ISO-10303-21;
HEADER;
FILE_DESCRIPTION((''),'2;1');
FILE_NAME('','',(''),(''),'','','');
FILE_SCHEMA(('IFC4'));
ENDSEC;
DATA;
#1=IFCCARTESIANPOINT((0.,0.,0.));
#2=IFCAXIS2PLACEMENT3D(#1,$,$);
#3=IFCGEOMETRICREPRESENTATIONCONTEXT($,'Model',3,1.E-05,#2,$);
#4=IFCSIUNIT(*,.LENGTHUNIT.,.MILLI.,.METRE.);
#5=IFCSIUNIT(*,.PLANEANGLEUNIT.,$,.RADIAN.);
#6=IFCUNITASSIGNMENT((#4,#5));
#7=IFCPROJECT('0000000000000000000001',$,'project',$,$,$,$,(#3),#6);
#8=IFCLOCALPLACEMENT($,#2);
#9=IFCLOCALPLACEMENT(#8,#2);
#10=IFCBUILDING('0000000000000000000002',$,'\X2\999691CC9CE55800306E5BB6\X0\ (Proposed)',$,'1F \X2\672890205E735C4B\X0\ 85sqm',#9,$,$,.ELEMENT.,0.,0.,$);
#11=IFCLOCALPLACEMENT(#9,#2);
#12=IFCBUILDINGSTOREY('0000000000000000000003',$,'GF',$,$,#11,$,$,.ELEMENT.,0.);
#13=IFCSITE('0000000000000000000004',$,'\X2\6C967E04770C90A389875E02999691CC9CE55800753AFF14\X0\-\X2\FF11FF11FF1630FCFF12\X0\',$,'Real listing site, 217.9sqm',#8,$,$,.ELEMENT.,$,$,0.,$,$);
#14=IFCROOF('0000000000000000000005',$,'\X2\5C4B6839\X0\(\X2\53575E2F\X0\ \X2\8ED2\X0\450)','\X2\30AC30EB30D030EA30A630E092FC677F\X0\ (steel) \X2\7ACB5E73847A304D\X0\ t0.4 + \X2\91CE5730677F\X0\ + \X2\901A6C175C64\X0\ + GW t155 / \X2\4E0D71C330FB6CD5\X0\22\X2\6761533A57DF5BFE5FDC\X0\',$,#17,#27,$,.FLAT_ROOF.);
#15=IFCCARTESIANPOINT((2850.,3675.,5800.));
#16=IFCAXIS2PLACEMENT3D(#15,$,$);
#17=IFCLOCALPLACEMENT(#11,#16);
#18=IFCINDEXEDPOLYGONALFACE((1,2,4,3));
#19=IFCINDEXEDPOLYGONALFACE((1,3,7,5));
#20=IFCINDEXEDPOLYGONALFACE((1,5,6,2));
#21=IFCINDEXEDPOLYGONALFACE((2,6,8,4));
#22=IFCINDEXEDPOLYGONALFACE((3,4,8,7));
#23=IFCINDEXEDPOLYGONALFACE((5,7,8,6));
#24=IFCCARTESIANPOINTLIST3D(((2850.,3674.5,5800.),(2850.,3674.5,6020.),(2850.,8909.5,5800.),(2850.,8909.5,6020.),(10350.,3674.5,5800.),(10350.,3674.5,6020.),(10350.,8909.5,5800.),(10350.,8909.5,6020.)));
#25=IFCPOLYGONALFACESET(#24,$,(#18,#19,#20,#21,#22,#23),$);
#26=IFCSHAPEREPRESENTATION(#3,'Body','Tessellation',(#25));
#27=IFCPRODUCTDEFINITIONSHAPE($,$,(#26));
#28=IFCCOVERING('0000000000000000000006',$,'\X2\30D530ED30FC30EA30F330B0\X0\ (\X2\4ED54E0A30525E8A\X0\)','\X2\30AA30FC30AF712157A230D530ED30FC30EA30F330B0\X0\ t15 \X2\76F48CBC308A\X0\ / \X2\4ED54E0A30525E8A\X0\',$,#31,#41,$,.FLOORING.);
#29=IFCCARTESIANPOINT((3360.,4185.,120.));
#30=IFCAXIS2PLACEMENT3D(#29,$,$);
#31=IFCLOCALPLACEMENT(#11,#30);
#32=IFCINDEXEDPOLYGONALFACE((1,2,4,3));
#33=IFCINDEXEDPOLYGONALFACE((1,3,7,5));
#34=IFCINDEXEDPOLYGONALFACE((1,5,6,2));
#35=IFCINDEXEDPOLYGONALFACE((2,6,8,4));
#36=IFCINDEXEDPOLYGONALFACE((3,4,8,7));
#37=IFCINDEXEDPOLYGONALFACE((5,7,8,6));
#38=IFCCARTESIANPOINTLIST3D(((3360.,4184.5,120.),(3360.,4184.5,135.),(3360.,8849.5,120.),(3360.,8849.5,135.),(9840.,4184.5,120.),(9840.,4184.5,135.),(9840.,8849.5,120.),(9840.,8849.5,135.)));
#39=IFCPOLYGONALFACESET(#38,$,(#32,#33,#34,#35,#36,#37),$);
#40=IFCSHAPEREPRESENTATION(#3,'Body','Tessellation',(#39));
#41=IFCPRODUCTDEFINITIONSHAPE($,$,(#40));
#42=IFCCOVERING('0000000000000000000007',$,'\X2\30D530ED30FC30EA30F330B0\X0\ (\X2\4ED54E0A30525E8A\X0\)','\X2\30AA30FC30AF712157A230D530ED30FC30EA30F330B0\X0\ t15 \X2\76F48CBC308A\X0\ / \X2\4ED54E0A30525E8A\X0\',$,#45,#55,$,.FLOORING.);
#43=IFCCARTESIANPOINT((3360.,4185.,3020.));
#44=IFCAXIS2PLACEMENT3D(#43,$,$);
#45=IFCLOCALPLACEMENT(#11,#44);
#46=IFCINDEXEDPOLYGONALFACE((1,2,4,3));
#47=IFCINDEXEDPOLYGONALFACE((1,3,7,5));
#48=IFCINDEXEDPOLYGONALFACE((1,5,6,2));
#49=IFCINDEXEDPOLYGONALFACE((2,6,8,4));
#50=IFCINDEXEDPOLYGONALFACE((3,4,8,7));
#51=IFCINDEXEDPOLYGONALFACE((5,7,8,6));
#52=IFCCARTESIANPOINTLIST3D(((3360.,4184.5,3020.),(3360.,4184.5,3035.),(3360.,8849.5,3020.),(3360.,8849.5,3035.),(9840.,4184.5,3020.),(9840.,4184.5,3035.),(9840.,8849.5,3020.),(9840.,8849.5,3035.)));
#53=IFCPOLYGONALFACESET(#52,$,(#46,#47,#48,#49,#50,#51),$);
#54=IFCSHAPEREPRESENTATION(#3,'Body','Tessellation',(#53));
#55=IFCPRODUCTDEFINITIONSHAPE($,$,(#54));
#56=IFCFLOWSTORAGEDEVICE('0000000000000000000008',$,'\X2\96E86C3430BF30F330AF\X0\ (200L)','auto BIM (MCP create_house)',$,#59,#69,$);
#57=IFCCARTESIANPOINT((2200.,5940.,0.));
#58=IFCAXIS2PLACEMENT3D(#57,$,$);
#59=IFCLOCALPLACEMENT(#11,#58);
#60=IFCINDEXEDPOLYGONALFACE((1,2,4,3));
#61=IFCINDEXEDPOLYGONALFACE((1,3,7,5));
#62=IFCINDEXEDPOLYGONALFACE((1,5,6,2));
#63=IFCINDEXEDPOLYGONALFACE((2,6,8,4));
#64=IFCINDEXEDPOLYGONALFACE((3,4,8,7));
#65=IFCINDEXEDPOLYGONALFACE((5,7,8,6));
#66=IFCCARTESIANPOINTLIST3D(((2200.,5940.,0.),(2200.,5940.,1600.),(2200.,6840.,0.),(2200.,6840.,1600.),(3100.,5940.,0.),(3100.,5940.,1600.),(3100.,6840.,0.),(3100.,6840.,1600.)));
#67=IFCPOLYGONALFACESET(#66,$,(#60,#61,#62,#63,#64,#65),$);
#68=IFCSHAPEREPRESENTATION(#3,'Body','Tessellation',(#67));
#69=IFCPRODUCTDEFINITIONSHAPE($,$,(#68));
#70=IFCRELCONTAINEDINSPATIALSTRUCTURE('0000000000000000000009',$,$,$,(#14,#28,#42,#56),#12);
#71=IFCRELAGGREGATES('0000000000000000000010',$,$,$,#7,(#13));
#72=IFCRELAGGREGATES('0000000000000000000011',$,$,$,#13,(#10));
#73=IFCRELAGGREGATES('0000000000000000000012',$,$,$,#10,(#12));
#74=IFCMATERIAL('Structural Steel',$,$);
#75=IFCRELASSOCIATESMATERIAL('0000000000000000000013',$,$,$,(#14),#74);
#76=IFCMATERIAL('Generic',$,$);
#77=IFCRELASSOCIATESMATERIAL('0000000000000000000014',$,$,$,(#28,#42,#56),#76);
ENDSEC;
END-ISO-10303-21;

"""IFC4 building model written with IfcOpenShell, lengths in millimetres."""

from ifc_helpers import new_model, si_unit, frame, frame_2d, origin, place, context, project, spatial, rectangle, extrude, material, element, save


model = new_model("IFC4")

# Units and contexts
model_context = context("Model", 3, precision=1e-05, world=origin())
ifc_project = project(units=[si_unit("LENGTHUNIT", "METRE", prefix="MILLI"), si_unit("PLANEANGLEUNIT", "RADIAN")], contexts=[model_context])

# Site, building, storey
site_placement = place(None, origin())
site = spatial("IfcSite", under=ifc_project, at=site_placement, Name="沖縄県那覇市首里鳥堀町４-１１６ー２", ObjectType="Real listing site, 217.9sqm", CompositionType="ELEMENT", RefElevation=0.0)
building_placement = place(site_placement, origin())
building = spatial("IfcBuilding", under=site, at=building_placement, Name="首里鳥堀の家 (Proposed)", ObjectType="1F 木造平屋 85sqm", CompositionType="ELEMENT", ElevationOfRefHeight=0.0, ElevationOfTerrain=0.0)
storey_placement = place(building_placement, origin())
storey = spatial("IfcBuildingStorey", under=building, at=storey_placement, Name="GF", CompositionType="ELEMENT", Elevation=0.0)

# Shared definitions
ifc_material_1 = material(Name="Generic")

# Roof
ifc_material_2 = material(Name="Structural Steel")
for number, where, name in (
    (1, (2850.0, 3675.0, 5800.0), "屋根(南帯 軒450)"),
):
    element("IfcRoof", number, at=place(storey_placement, frame(where)), inside=storey, material=ifc_material_2, Name=name, Description="ガルバリウム鋼板 (steel) 立平葺き t0.4 + 野地板 + 通気層 + GW t155 / 不燃・法22条区域対応", PredefinedType="FLAT_ROOF", context=model_context, shape_type="SweptSolid", body=[
        extrude(rectangle(XDim=7500.0, YDim=5235.0, at=frame_2d((3750.0, 2617.0))), frame((2850.0, 3675.0, 5800.0)), (0.0, 0.0, 1.0), 220.0),
    ])

# Coverings
covering_1_placement = place(storey_placement, frame((3360.0, 4185.0, 120.0)))
element("IfcCovering", 2, at=covering_1_placement, inside=storey, material=ifc_material_1, Name="フローリング (仕上げ床)", Description="オーク無垢フローリング t15 直貼り / 仕上げ床", PredefinedType="FLOORING", context=model_context, shape_type="SweptSolid", body=[
    extrude(rectangle(XDim=6480.0, YDim=4665.0, at=frame_2d((3240.0, 2332.0))), frame((3360.0, 4185.0, 120.0)), (0.0, 0.0, 1.0), 15.0),
])
covering_2_placement = place(storey_placement, frame((3360.0, 4185.0, 3020.0)))
element("IfcCovering", 3, at=covering_2_placement, inside=storey, material=ifc_material_1, Name="フローリング (仕上げ床)", Description="オーク無垢フローリング t15 直貼り / 仕上げ床", PredefinedType="FLOORING", context=model_context, shape_type="SweptSolid", body=[
    extrude(rectangle(XDim=6480.0, YDim=4665.0, at=frame_2d((3240.0, 2332.0))), frame((3360.0, 4185.0, 3020.0)), (0.0, 0.0, 1.0), 15.0),
])

# Flow storage device
flow_storage_device_placement = place(storey_placement, frame((2200.0, 5940.0, 0.0)))
element("IfcFlowStorageDevice", 4, at=flow_storage_device_placement, inside=storey, material=ifc_material_1, Name="雨水タンク (200L)", Description="auto BIM (MCP create_house)", context=model_context, shape_type="SweptSolid", body=[
    extrude(rectangle(XDim=900.0, YDim=900.0, at=frame_2d((450.0, 450.0))), frame((2200.0, 5940.0, 0.0)), (0.0, 0.0, 1.0), 1600.0),
])

save(model, "model.ifc")
